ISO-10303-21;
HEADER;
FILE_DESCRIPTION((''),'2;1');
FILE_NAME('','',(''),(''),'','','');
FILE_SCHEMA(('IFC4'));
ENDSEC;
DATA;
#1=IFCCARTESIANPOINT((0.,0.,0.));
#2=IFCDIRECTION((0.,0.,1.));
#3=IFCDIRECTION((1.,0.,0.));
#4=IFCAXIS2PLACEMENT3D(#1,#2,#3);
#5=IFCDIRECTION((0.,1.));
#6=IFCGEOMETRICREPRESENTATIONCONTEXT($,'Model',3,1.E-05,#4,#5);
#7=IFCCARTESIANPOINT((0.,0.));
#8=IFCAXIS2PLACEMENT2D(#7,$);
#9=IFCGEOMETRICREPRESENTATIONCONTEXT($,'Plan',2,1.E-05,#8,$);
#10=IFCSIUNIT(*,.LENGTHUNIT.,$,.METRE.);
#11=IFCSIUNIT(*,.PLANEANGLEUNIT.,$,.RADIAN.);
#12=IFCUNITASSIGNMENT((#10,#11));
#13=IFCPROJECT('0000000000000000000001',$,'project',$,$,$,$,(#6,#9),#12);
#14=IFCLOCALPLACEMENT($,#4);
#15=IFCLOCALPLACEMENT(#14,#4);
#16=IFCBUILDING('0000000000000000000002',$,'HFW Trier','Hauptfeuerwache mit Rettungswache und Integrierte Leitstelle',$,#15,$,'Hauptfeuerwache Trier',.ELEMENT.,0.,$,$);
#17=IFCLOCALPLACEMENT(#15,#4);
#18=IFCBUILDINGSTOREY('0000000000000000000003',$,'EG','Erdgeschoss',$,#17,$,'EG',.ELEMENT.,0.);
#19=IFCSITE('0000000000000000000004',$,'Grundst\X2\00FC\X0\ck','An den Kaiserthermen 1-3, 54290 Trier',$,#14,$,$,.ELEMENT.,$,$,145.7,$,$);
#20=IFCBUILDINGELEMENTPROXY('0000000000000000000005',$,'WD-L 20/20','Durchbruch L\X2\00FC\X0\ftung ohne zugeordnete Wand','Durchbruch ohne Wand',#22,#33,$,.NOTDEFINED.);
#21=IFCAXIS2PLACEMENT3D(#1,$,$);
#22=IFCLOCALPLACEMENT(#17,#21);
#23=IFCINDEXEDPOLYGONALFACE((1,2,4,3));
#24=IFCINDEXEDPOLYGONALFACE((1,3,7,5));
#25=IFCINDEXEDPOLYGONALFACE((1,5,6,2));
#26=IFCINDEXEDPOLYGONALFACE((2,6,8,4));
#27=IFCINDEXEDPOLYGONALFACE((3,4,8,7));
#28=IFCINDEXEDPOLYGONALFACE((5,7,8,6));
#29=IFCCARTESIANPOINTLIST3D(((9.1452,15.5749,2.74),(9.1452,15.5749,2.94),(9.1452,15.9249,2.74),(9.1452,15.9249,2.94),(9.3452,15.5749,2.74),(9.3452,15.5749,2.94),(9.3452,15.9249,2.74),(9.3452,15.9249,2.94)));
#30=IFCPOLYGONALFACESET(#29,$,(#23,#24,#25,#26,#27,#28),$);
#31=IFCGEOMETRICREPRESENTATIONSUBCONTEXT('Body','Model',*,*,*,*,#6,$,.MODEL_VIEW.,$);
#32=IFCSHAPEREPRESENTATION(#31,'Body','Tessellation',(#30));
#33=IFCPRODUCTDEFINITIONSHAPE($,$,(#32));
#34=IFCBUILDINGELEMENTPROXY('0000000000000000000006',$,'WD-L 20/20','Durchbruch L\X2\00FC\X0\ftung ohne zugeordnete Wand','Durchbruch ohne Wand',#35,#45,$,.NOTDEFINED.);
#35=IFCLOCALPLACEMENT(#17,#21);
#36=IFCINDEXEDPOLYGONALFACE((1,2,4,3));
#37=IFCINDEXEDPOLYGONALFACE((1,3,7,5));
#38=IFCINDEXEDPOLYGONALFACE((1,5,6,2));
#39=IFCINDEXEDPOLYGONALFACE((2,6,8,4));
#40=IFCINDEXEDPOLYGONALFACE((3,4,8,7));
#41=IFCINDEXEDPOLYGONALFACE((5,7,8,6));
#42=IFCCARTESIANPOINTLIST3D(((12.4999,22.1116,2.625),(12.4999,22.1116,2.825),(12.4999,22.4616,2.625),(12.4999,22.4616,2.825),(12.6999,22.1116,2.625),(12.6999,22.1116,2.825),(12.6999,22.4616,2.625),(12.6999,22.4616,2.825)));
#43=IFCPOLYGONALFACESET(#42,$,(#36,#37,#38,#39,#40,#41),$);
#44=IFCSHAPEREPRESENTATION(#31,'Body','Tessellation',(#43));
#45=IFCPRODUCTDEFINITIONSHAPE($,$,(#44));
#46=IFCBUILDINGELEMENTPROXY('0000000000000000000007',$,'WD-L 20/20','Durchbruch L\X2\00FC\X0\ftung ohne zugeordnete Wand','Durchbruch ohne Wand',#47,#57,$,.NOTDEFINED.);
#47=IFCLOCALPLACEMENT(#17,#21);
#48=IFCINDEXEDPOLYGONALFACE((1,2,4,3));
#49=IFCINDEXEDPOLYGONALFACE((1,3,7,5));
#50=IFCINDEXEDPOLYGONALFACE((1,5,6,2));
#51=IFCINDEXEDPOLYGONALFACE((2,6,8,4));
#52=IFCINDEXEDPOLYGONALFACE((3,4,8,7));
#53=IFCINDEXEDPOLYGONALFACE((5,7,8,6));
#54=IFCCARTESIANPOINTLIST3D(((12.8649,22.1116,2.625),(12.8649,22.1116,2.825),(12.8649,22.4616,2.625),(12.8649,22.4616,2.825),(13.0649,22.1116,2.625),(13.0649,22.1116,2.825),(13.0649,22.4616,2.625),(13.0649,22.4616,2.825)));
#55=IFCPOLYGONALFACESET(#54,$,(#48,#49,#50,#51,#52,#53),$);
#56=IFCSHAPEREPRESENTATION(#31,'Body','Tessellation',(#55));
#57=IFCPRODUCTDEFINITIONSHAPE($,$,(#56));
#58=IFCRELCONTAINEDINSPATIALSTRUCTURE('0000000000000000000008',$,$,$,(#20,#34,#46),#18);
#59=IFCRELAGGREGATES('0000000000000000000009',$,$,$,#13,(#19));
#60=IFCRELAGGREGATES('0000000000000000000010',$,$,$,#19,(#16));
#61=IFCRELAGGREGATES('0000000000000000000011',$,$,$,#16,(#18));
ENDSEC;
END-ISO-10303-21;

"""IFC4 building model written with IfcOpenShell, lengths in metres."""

from ifc_helpers import new_model, si_unit, direction, frame, origin_with_axes, origin_2d, place, context, subcontext, project, spatial, rectangle, extrude, element, save


model = new_model("IFC4")

# Units and contexts
model_context = context("Model", 3, precision=1e-05, world=origin_with_axes(), true_north=direction((0.0, 1.0)))
plan_context = context("Plan", 2, precision=1e-05, world=origin_2d())
body_context = subcontext(model_context, "Body", "Model", "MODEL_VIEW")
ifc_project = project(units=[si_unit("LENGTHUNIT", "METRE"), si_unit("PLANEANGLEUNIT", "RADIAN")], contexts=[model_context, plan_context])

# Site, building, storey
site_placement = place(None, origin_with_axes())
site = spatial("IfcSite", under=ifc_project, at=site_placement, Name="Grundstück", Description="An den Kaiserthermen 1-3, 54290 Trier", CompositionType="ELEMENT", RefElevation=145.7)
building_placement = place(site_placement, origin_with_axes())
building = spatial("IfcBuilding", under=site, at=building_placement, Name="HFW Trier", Description="Hauptfeuerwache mit Rettungswache und Integrierte Leitstelle", LongName="Hauptfeuerwache Trier", CompositionType="ELEMENT", ElevationOfRefHeight=0.0)
storey_placement = place(building_placement, origin_with_axes())
storey = spatial("IfcBuildingStorey", under=building, at=storey_placement, Name="EG", Description="Erdgeschoss", LongName="EG", CompositionType="ELEMENT", Elevation=0.0)

# Building element proxies
for number, where, z_axis, x_axis, name in (
    (1, (9.2452, 15.7499, 2.74), (0.0, 0.0, 1.0), (1.0, 0.0, 0.0), "WD-L 20/20"),
    (2, (12.5999, 22.2866, 2.625), (0.0, 0.0, 1.0), (1.0, 0.0, 0.0), "WD-L 20/20"),
    (3, (12.9649, 22.2866, 2.625), (0.0, 0.0, 1.0), (1.0, 0.0, 0.0), "WD-L 20/20"),
):
    element("IfcBuildingElementProxy", number, at=place(storey_placement, frame(where, z_axis=z_axis, x_axis=x_axis)), inside=storey, Name=name, Description="Durchbruch Lüftung ohne zugeordnete Wand", ObjectType="Durchbruch ohne Wand", PredefinedType="NOTDEFINED", context=body_context, shape_type="SweptSolid", body=[
        extrude(rectangle(XDim=0.2, YDim=0.35, at=origin_2d()), origin_with_axes(), (0.0, 0.0, 1.0), 0.2),
    ])

save(model, "model.ifc")
